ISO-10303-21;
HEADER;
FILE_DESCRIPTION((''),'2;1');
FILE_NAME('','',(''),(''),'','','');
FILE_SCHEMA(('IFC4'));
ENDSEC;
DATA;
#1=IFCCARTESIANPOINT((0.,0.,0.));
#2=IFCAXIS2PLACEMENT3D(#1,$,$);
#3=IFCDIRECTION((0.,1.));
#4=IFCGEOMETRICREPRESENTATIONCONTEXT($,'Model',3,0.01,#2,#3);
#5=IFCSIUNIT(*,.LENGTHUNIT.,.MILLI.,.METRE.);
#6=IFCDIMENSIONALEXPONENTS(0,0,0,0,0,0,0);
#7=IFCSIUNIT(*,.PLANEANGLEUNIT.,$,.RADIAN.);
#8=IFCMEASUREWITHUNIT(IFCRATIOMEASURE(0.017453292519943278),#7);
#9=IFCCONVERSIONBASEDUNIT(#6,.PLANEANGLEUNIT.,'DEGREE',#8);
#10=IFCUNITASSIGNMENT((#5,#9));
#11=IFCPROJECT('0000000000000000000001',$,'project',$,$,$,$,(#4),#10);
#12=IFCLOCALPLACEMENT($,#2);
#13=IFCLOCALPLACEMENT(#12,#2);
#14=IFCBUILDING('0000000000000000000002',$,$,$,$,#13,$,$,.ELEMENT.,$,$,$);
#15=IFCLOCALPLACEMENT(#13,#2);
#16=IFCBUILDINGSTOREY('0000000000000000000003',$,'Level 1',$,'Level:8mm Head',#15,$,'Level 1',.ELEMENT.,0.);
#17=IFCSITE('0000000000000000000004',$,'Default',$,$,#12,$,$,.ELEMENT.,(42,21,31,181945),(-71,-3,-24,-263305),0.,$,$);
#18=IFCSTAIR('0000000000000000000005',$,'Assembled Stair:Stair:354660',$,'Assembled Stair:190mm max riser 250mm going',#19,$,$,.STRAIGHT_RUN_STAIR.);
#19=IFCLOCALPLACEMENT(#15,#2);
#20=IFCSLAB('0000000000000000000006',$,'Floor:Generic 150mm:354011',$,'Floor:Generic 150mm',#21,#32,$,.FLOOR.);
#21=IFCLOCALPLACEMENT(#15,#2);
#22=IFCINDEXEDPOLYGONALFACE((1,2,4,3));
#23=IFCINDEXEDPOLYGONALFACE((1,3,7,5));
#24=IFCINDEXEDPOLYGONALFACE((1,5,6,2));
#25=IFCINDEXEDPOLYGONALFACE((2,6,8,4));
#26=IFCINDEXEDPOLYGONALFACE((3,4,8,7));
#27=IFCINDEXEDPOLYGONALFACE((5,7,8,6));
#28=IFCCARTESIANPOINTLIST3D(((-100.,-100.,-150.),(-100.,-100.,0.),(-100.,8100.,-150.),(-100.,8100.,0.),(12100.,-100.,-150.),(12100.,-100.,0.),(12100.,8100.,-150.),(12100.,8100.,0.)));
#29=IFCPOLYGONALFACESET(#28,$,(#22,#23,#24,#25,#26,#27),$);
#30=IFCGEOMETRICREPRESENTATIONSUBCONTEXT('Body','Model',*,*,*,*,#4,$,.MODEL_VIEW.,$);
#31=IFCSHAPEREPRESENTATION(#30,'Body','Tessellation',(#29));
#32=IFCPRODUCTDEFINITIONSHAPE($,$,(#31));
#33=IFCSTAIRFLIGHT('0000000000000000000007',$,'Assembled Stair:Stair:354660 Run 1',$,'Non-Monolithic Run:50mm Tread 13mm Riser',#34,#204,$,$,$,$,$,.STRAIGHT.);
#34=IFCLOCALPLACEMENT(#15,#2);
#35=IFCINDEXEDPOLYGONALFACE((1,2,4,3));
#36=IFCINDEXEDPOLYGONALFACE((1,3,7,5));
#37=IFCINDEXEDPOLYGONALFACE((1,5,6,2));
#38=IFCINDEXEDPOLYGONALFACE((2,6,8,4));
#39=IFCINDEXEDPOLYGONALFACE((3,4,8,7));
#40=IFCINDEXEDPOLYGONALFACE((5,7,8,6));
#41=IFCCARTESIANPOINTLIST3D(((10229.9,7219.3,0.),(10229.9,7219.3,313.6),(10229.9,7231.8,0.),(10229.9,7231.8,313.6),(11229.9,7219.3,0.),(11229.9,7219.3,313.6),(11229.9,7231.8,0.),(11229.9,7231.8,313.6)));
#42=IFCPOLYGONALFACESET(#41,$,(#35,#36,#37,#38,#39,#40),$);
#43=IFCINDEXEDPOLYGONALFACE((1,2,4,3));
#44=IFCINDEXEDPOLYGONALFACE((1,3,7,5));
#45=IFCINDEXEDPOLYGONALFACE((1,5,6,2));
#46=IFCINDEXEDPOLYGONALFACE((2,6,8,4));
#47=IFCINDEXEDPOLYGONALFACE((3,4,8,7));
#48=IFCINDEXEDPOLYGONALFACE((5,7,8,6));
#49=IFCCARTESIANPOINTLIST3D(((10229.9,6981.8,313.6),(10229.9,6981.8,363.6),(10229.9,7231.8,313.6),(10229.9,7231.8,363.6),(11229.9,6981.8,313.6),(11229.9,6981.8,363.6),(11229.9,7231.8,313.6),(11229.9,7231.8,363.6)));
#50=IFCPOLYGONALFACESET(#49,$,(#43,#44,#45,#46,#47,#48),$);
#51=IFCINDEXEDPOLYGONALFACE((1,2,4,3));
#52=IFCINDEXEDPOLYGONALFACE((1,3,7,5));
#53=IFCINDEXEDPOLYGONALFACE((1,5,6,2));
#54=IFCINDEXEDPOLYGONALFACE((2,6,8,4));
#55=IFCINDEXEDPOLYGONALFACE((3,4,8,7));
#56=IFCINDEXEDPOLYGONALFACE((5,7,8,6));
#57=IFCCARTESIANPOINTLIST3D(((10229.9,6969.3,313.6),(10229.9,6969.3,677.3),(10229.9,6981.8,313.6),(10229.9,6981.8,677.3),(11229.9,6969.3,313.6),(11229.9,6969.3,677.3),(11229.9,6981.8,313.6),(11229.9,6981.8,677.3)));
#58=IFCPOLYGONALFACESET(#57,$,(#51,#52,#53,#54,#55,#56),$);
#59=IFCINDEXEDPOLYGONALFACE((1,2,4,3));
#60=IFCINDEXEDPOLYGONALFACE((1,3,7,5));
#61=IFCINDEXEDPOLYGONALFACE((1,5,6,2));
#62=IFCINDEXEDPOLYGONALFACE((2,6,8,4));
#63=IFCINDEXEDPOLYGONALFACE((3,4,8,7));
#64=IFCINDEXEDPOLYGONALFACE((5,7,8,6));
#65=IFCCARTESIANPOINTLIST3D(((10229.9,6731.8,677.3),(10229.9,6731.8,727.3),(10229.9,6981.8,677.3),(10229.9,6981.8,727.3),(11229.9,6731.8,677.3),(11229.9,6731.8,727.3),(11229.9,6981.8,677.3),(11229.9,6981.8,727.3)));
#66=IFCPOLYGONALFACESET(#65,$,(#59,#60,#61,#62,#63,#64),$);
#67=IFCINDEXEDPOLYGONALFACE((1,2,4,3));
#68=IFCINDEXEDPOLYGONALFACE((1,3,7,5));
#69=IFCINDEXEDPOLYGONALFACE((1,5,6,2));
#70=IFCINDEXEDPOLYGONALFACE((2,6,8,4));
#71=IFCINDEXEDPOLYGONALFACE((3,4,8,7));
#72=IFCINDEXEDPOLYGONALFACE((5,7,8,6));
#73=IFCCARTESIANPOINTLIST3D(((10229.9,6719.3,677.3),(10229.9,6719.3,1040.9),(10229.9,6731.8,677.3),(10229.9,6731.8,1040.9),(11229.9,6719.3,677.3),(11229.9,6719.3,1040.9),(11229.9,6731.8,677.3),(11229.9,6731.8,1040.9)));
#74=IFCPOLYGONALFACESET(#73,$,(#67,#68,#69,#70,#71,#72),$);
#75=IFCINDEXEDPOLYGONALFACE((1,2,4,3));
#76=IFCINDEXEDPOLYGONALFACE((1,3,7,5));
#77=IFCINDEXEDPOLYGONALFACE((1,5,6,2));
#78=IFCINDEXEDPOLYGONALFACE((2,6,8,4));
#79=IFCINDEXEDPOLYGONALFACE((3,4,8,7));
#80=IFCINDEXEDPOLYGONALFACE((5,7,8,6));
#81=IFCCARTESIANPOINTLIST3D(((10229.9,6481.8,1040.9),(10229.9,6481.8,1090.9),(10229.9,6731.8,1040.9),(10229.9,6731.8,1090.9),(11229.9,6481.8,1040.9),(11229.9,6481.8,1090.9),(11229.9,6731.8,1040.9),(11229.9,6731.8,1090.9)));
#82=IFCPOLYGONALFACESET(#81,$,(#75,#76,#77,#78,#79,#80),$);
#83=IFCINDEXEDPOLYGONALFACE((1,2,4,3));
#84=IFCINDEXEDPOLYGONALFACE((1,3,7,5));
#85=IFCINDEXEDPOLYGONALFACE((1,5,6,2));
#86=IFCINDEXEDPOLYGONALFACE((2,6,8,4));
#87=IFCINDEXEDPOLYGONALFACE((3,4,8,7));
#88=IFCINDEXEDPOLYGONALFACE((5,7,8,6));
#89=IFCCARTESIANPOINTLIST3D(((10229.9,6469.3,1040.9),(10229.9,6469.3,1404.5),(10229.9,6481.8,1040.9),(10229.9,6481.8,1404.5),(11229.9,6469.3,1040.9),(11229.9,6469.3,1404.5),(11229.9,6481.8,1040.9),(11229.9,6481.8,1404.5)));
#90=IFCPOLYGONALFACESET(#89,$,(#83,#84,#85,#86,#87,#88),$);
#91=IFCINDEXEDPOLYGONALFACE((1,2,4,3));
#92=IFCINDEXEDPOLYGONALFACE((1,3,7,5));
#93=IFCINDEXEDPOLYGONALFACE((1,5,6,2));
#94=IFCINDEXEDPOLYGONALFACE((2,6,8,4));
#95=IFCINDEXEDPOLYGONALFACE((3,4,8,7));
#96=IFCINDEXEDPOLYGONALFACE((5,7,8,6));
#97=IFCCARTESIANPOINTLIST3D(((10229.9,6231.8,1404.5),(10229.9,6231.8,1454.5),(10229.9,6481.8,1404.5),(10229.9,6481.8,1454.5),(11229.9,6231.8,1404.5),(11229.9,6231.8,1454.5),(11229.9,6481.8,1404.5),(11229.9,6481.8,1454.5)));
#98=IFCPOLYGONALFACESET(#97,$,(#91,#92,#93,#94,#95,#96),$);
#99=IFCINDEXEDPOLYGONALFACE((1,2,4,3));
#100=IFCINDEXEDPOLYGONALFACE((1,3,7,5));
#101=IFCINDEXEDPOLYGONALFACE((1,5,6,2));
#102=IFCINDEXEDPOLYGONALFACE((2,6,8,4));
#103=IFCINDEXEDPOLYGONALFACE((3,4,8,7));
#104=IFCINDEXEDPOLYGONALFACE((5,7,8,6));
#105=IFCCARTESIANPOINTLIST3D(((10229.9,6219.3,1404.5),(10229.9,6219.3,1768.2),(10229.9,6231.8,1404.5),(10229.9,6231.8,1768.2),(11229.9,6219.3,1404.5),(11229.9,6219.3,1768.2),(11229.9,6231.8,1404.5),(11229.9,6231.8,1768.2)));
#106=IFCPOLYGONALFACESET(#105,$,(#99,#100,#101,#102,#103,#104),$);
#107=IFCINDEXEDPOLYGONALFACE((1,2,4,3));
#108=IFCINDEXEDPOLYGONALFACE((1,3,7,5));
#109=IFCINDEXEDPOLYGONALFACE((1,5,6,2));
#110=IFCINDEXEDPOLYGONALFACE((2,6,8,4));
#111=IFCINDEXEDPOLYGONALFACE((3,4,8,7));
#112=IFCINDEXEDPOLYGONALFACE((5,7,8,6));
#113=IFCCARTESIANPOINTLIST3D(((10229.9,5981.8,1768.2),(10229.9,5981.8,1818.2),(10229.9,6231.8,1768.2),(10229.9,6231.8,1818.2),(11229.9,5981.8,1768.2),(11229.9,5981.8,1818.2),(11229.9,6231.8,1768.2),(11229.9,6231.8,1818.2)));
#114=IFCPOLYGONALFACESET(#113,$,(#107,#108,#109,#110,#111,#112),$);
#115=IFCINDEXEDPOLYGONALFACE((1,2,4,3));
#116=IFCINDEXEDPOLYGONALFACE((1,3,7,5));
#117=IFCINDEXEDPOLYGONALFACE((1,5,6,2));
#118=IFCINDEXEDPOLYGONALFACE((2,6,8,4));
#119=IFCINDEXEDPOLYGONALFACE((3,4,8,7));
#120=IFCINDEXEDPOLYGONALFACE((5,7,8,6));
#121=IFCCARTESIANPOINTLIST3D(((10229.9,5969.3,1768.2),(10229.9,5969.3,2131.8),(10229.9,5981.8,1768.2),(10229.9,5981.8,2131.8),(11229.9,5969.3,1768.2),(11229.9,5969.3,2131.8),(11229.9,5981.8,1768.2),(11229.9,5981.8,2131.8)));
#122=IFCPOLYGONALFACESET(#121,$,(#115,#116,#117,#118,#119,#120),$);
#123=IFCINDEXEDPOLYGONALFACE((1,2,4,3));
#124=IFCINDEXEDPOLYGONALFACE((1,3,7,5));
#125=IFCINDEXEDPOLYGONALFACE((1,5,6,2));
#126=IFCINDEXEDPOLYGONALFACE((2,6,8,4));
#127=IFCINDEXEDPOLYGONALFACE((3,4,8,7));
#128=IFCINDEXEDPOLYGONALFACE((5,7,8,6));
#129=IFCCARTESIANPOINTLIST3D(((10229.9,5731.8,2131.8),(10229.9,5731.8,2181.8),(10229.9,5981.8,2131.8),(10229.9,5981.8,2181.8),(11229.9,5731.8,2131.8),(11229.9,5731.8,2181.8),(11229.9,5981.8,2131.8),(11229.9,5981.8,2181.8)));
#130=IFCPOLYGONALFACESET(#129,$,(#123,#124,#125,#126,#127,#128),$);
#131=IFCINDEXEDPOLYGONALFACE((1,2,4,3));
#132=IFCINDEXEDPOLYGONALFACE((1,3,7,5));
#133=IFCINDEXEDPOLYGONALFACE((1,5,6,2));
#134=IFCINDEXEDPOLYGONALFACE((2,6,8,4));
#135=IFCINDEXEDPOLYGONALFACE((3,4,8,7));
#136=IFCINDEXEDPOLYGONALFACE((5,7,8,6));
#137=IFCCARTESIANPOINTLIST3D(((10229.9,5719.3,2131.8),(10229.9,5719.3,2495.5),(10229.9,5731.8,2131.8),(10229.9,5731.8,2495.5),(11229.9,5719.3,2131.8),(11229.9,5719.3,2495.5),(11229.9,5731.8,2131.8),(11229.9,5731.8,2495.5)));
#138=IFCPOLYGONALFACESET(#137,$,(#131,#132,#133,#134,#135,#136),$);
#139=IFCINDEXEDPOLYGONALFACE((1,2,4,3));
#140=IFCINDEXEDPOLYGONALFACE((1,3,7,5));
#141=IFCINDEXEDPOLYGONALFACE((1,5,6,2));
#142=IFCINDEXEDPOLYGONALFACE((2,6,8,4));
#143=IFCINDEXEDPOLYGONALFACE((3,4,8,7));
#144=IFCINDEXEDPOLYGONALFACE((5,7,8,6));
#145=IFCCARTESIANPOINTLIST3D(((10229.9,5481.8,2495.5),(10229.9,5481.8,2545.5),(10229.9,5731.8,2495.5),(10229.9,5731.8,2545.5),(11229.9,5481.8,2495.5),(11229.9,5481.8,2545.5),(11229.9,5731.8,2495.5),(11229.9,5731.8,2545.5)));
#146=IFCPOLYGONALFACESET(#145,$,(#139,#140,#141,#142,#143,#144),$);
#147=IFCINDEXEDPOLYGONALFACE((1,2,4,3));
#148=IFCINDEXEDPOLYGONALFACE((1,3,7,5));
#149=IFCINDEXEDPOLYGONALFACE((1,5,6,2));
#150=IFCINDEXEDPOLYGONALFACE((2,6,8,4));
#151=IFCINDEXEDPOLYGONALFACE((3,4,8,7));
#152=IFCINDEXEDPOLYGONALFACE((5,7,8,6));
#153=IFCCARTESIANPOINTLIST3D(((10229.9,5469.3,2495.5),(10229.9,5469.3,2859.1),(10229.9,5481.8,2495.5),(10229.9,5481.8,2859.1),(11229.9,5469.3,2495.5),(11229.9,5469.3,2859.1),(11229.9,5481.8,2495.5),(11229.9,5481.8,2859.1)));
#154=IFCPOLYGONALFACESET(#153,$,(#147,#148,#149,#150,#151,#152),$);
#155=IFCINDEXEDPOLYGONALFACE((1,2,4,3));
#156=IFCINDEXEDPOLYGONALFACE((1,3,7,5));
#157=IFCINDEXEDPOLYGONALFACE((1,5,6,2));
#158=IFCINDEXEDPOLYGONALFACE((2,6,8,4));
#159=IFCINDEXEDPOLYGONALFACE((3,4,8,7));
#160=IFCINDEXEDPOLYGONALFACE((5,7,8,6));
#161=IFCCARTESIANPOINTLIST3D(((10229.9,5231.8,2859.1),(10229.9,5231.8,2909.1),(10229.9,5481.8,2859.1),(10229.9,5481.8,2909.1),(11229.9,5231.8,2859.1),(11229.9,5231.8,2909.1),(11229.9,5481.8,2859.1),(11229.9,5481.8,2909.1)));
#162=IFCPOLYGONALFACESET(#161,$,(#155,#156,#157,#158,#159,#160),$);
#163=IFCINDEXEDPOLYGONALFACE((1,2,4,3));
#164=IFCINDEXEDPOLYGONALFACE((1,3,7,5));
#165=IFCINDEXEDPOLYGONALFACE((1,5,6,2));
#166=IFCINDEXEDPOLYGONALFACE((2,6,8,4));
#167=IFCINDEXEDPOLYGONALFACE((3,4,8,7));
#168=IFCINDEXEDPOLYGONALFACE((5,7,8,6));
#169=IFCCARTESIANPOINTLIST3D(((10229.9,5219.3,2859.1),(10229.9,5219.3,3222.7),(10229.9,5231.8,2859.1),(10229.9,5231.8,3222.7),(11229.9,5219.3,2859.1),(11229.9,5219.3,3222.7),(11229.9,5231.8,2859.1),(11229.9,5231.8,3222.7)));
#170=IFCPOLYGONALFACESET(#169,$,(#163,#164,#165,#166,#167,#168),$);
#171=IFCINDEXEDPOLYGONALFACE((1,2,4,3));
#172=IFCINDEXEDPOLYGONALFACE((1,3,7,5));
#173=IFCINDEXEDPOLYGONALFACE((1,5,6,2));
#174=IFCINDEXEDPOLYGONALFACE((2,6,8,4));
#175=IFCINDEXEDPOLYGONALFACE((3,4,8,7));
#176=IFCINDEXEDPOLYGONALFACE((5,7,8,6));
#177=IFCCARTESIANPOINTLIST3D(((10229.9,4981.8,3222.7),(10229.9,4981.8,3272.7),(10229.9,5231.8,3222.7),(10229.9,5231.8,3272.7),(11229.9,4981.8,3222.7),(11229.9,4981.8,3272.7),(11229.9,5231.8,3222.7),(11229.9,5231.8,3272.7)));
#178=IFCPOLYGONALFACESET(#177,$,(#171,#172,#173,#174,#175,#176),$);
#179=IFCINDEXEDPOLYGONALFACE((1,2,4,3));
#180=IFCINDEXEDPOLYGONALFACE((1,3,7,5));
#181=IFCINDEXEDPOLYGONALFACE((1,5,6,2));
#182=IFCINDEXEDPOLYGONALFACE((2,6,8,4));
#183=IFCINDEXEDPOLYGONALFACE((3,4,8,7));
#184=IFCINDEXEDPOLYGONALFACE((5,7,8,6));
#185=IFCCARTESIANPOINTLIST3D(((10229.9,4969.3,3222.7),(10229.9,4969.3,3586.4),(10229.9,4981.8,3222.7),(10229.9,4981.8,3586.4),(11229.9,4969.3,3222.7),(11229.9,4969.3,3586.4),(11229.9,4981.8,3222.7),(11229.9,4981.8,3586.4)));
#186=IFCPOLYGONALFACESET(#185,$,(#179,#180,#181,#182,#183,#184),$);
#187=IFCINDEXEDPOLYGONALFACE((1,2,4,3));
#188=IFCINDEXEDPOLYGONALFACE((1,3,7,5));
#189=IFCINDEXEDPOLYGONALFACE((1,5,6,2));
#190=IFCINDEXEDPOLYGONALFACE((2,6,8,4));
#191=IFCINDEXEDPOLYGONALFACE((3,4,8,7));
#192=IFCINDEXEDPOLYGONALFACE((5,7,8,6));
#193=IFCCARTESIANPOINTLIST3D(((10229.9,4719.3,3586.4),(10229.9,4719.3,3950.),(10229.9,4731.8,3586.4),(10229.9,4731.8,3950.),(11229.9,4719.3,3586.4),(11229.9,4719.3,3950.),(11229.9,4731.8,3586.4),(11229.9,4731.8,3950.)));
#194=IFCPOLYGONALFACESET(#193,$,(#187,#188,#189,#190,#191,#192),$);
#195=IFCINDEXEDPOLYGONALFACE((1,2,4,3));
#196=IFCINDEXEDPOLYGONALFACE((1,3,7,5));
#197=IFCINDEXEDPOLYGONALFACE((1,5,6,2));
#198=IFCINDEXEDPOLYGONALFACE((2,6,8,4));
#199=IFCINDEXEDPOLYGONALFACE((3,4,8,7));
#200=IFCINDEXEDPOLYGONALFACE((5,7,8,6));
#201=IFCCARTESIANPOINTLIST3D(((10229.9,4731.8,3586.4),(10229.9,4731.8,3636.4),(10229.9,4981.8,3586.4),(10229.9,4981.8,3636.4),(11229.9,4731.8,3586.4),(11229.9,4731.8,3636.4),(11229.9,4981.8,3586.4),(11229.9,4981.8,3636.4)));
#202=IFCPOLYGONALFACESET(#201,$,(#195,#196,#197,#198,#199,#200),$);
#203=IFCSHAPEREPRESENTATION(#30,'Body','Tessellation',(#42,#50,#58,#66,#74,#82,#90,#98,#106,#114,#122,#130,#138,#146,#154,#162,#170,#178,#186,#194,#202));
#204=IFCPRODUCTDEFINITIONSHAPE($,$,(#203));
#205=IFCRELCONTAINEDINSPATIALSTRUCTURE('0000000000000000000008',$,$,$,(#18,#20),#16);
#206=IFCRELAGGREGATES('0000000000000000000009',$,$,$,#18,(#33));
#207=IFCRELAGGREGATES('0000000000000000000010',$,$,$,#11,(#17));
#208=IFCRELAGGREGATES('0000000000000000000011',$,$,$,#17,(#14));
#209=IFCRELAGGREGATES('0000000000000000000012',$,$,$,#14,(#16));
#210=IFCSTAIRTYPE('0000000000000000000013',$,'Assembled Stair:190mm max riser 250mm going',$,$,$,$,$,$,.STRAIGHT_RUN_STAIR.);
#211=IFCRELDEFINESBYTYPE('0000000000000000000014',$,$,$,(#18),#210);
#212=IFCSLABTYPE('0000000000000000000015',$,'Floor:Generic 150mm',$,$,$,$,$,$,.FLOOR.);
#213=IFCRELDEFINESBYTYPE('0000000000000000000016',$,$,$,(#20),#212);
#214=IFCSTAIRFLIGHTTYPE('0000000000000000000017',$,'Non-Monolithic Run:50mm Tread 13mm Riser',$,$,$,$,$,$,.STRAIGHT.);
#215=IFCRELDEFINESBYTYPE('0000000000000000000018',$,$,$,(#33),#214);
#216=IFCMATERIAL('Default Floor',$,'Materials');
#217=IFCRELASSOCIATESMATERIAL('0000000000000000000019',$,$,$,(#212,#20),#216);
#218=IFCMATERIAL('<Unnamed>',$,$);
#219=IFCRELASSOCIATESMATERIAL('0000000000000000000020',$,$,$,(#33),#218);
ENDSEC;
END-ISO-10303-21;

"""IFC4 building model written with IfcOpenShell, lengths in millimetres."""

from ifc_helpers import new_model, entity, si_unit, converted_unit, direction, frame, origin, place, context, subcontext, project, spatial, indexed_curve, outline, extrude, material, type_object, element, aggregate, save


model = new_model("IFC4")

# Units and contexts
model_context = context("Model", 3, precision=0.01, world=origin(), true_north=direction((0.0, 1.0)))
body_context = subcontext(model_context, "Body", "Model", "MODEL_VIEW")
ifc_project = project(units=[si_unit("LENGTHUNIT", "METRE", prefix="MILLI"), converted_unit("PLANEANGLEUNIT", "DEGREE", entity("IfcRatioMeasure", 0.017453292519943278), si_unit("PLANEANGLEUNIT", "RADIAN"), dimensions=[0, 0, 0, 0, 0, 0, 0])], contexts=[model_context])

# Site, building, storey
site_placement = place(None, origin())
site = spatial("IfcSite", under=ifc_project, at=site_placement, Name="Default", CompositionType="ELEMENT", RefLatitude=(42, 21, 31, 181945), RefLongitude=(-71, -3, -24, -263305), RefElevation=0.0)
building_placement = place(site_placement, origin())
building = spatial("IfcBuilding", under=site, at=building_placement, CompositionType="ELEMENT")
storey_placement = place(building_placement, origin())
storey = spatial("IfcBuildingStorey", under=building, at=storey_placement, Name="Level 1", ObjectType="Level:8mm Head", LongName="Level 1", CompositionType="ELEMENT", Elevation=0.0)

# Stair
stair_type = type_object("IfcStairType", Name="Assembled Stair:190mm max riser 250mm going", PredefinedType="STRAIGHT_RUN_STAIR")
stair_placement = place(storey_placement, origin())
stair = element("IfcStair", 1, at=stair_placement, inside=storey, type_object=stair_type, Name="Assembled Stair:Stair:354660", ObjectType="Assembled Stair:190mm max riser 250mm going", PredefinedType="STRAIGHT_RUN_STAIR")
ifc_material_1 = material(Name="<Unnamed>")

# Slab
ifc_material_2 = material(Name="Default Floor", Category="Materials")
slab_type = type_object("IfcSlabType", Name="Floor:Generic 150mm", PredefinedType="FLOOR", material=ifc_material_2)
slab_placement = place(storey_placement, origin())
element("IfcSlab", 2, at=slab_placement, inside=storey, type_object=slab_type, material=ifc_material_2, Name="Floor:Generic 150mm:354011", ObjectType="Floor:Generic 150mm", PredefinedType="FLOOR", context=body_context, shape_type="SweptSolid", body=[
    extrude(outline(indexed_curve([(-4100.0, -6100.0), (4100.0, -6100.0), (4100.0, 6100.0), (-4100.0, 6100.0), (-4100.0, -6100.0)], self_intersect=False)), frame((6000.0, 4000.0, 0.0), z_axis=(0.0, 0.0, -1.0), x_axis=(0.0, 1.0, 0.0)), (0.0, 0.0, 1.0), 150.0),
])

# Stair flight
stair_flight_type = type_object("IfcStairFlightType", Name="Non-Monolithic Run:50mm Tread 13mm Riser", PredefinedType="STRAIGHT")
stair_flight_placement = place(stair_placement, origin())
stair_flight = element("IfcStairFlight", 3, at=stair_flight_placement, type_object=stair_flight_type, material=ifc_material_1, Name="Assembled Stair:Stair:354660 Run 1", ObjectType="Non-Monolithic Run:50mm Tread 13mm Riser", PredefinedType="STRAIGHT", context=body_context, shape_type="SweptSolid", body=[
    extrude(outline(indexed_curve([(-500.0, -6.2), (500.0, -6.2), (500.0, 6.3), (-500.0, 6.3), (-500.0, -6.2)], self_intersect=False)), frame((10729.9, 7225.6, 0.0)), (0.0, 0.0, 1.0), 313.6),
    extrude(outline(indexed_curve([(-125.0, -500.0), (125.0, -500.0), (125.0, 500.0), (-125.0, 500.0), (-125.0, -500.0)], self_intersect=False)), frame((10729.9, 7106.8, 313.6), z_axis=(0.0, 0.0, 1.0), x_axis=(0.0, 1.0, 0.0)), (0.0, 0.0, 1.0), 50.0),
    extrude(outline(indexed_curve([(-500.0, -6.2), (500.0, -6.2), (500.0, 6.3), (-500.0, 6.3), (-500.0, -6.2)], self_intersect=False)), frame((10729.9, 6975.6, 313.6)), (0.0, 0.0, 1.0), 363.6),
    extrude(outline(indexed_curve([(-125.0, -500.0), (125.0, -500.0), (125.0, 500.0), (-125.0, 500.0), (-125.0, -500.0)], self_intersect=False)), frame((10729.9, 6856.8, 677.3), z_axis=(0.0, 0.0, 1.0), x_axis=(0.0, 1.0, 0.0)), (0.0, 0.0, 1.0), 50.0),
    extrude(outline(indexed_curve([(-500.0, -6.2), (500.0, -6.2), (500.0, 6.3), (-500.0, 6.3), (-500.0, -6.2)], self_intersect=False)), frame((10729.9, 6725.6, 677.3)), (0.0, 0.0, 1.0), 363.6),
    extrude(outline(indexed_curve([(-125.0, -500.0), (125.0, -500.0), (125.0, 500.0), (-125.0, 500.0), (-125.0, -500.0)], self_intersect=False)), frame((10729.9, 6606.8, 1040.9), z_axis=(0.0, 0.0, 1.0), x_axis=(0.0, 1.0, 0.0)), (0.0, 0.0, 1.0), 50.0),
    extrude(outline(indexed_curve([(-500.0, -6.2), (500.0, -6.2), (500.0, 6.3), (-500.0, 6.3), (-500.0, -6.2)], self_intersect=False)), frame((10729.9, 6475.6, 1040.9)), (0.0, 0.0, 1.0), 363.6),
    extrude(outline(indexed_curve([(-125.0, -500.0), (125.0, -500.0), (125.0, 500.0), (-125.0, 500.0), (-125.0, -500.0)], self_intersect=False)), frame((10729.9, 6356.8, 1404.5), z_axis=(0.0, 0.0, 1.0), x_axis=(0.0, 1.0, 0.0)), (0.0, 0.0, 1.0), 50.0),
    extrude(outline(indexed_curve([(-500.0, -6.2), (500.0, -6.2), (500.0, 6.3), (-500.0, 6.3), (-500.0, -6.2)], self_intersect=False)), frame((10729.9, 6225.6, 1404.5)), (0.0, 0.0, 1.0), 363.6),
    extrude(outline(indexed_curve([(-125.0, -500.0), (125.0, -500.0), (125.0, 500.0), (-125.0, 500.0), (-125.0, -500.0)], self_intersect=False)), frame((10729.9, 6106.8, 1768.2), z_axis=(0.0, 0.0, 1.0), x_axis=(0.0, 1.0, 0.0)), (0.0, 0.0, 1.0), 50.0),
    extrude(outline(indexed_curve([(-500.0, -6.3), (500.0, -6.3), (500.0, 6.2), (-500.0, 6.2), (-500.0, -6.3)], self_intersect=False)), frame((10729.9, 5975.6, 1768.2)), (0.0, 0.0, 1.0), 363.6),
    extrude(outline(indexed_curve([(-125.0, -500.0), (125.0, -500.0), (125.0, 500.0), (-125.0, 500.0), (-125.0, -500.0)], self_intersect=False)), frame((10729.9, 5856.8, 2131.8), z_axis=(0.0, 0.0, 1.0), x_axis=(0.0, 1.0, 0.0)), (0.0, 0.0, 1.0), 50.0),
    extrude(outline(indexed_curve([(-500.0, -6.3), (500.0, -6.3), (500.0, 6.2), (-500.0, 6.2), (-500.0, -6.3)], self_intersect=False)), frame((10729.9, 5725.6, 2131.8)), (0.0, 0.0, 1.0), 363.6),
    extrude(outline(indexed_curve([(-125.0, -500.0), (125.0, -500.0), (125.0, 500.0), (-125.0, 500.0), (-125.0, -500.0)], self_intersect=False)), frame((10729.9, 5606.8, 2495.5), z_axis=(0.0, 0.0, 1.0), x_axis=(0.0, 1.0, 0.0)), (0.0, 0.0, 1.0), 50.0),
    extrude(outline(indexed_curve([(-500.0, -6.2), (500.0, -6.2), (500.0, 6.3), (-500.0, 6.3), (-500.0, -6.2)], self_intersect=False)), frame((10729.9, 5475.6, 2495.5)), (0.0, 0.0, 1.0), 363.6),
    extrude(outline(indexed_curve([(-125.0, -500.0), (125.0, -500.0), (125.0, 500.0), (-125.0, 500.0), (-125.0, -500.0)], self_intersect=False)), frame((10729.9, 5356.8, 2859.1), z_axis=(0.0, 0.0, 1.0), x_axis=(0.0, 1.0, 0.0)), (0.0, 0.0, 1.0), 50.0),
    extrude(outline(indexed_curve([(-500.0, -6.2), (500.0, -6.2), (500.0, 6.3), (-500.0, 6.3), (-500.0, -6.2)], self_intersect=False)), frame((10729.9, 5225.6, 2859.1)), (0.0, 0.0, 1.0), 363.6),
    extrude(outline(indexed_curve([(-125.0, -500.0), (125.0, -500.0), (125.0, 500.0), (-125.0, 500.0), (-125.0, -500.0)], self_intersect=False)), frame((10729.9, 5106.8, 3222.7), z_axis=(0.0, 0.0, 1.0), x_axis=(0.0, 1.0, 0.0)), (0.0, 0.0, 1.0), 50.0),
    extrude(outline(indexed_curve([(-500.0, -6.2), (500.0, -6.2), (500.0, 6.3), (-500.0, 6.3), (-500.0, -6.2)], self_intersect=False)), frame((10729.9, 4975.6, 3222.7)), (0.0, 0.0, 1.0), 363.6),
    extrude(outline(indexed_curve([(-500.0, -6.2), (500.0, -6.2), (500.0, 6.3), (-500.0, 6.3), (-500.0, -6.2)], self_intersect=False)), frame((10729.9, 4725.6, 3586.4)), (0.0, 0.0, 1.0), 363.6),
    extrude(outline(indexed_curve([(-125.0, -500.0), (125.0, -500.0), (125.0, 500.0), (-125.0, 500.0), (-125.0, -500.0)], self_intersect=False)), frame((10729.9, 4856.8, 3586.4), z_axis=(0.0, 0.0, 1.0), x_axis=(0.0, 1.0, 0.0)), (0.0, 0.0, 1.0), 50.0),
])

aggregate(stair, [stair_flight])

save(model, "model.ifc")
